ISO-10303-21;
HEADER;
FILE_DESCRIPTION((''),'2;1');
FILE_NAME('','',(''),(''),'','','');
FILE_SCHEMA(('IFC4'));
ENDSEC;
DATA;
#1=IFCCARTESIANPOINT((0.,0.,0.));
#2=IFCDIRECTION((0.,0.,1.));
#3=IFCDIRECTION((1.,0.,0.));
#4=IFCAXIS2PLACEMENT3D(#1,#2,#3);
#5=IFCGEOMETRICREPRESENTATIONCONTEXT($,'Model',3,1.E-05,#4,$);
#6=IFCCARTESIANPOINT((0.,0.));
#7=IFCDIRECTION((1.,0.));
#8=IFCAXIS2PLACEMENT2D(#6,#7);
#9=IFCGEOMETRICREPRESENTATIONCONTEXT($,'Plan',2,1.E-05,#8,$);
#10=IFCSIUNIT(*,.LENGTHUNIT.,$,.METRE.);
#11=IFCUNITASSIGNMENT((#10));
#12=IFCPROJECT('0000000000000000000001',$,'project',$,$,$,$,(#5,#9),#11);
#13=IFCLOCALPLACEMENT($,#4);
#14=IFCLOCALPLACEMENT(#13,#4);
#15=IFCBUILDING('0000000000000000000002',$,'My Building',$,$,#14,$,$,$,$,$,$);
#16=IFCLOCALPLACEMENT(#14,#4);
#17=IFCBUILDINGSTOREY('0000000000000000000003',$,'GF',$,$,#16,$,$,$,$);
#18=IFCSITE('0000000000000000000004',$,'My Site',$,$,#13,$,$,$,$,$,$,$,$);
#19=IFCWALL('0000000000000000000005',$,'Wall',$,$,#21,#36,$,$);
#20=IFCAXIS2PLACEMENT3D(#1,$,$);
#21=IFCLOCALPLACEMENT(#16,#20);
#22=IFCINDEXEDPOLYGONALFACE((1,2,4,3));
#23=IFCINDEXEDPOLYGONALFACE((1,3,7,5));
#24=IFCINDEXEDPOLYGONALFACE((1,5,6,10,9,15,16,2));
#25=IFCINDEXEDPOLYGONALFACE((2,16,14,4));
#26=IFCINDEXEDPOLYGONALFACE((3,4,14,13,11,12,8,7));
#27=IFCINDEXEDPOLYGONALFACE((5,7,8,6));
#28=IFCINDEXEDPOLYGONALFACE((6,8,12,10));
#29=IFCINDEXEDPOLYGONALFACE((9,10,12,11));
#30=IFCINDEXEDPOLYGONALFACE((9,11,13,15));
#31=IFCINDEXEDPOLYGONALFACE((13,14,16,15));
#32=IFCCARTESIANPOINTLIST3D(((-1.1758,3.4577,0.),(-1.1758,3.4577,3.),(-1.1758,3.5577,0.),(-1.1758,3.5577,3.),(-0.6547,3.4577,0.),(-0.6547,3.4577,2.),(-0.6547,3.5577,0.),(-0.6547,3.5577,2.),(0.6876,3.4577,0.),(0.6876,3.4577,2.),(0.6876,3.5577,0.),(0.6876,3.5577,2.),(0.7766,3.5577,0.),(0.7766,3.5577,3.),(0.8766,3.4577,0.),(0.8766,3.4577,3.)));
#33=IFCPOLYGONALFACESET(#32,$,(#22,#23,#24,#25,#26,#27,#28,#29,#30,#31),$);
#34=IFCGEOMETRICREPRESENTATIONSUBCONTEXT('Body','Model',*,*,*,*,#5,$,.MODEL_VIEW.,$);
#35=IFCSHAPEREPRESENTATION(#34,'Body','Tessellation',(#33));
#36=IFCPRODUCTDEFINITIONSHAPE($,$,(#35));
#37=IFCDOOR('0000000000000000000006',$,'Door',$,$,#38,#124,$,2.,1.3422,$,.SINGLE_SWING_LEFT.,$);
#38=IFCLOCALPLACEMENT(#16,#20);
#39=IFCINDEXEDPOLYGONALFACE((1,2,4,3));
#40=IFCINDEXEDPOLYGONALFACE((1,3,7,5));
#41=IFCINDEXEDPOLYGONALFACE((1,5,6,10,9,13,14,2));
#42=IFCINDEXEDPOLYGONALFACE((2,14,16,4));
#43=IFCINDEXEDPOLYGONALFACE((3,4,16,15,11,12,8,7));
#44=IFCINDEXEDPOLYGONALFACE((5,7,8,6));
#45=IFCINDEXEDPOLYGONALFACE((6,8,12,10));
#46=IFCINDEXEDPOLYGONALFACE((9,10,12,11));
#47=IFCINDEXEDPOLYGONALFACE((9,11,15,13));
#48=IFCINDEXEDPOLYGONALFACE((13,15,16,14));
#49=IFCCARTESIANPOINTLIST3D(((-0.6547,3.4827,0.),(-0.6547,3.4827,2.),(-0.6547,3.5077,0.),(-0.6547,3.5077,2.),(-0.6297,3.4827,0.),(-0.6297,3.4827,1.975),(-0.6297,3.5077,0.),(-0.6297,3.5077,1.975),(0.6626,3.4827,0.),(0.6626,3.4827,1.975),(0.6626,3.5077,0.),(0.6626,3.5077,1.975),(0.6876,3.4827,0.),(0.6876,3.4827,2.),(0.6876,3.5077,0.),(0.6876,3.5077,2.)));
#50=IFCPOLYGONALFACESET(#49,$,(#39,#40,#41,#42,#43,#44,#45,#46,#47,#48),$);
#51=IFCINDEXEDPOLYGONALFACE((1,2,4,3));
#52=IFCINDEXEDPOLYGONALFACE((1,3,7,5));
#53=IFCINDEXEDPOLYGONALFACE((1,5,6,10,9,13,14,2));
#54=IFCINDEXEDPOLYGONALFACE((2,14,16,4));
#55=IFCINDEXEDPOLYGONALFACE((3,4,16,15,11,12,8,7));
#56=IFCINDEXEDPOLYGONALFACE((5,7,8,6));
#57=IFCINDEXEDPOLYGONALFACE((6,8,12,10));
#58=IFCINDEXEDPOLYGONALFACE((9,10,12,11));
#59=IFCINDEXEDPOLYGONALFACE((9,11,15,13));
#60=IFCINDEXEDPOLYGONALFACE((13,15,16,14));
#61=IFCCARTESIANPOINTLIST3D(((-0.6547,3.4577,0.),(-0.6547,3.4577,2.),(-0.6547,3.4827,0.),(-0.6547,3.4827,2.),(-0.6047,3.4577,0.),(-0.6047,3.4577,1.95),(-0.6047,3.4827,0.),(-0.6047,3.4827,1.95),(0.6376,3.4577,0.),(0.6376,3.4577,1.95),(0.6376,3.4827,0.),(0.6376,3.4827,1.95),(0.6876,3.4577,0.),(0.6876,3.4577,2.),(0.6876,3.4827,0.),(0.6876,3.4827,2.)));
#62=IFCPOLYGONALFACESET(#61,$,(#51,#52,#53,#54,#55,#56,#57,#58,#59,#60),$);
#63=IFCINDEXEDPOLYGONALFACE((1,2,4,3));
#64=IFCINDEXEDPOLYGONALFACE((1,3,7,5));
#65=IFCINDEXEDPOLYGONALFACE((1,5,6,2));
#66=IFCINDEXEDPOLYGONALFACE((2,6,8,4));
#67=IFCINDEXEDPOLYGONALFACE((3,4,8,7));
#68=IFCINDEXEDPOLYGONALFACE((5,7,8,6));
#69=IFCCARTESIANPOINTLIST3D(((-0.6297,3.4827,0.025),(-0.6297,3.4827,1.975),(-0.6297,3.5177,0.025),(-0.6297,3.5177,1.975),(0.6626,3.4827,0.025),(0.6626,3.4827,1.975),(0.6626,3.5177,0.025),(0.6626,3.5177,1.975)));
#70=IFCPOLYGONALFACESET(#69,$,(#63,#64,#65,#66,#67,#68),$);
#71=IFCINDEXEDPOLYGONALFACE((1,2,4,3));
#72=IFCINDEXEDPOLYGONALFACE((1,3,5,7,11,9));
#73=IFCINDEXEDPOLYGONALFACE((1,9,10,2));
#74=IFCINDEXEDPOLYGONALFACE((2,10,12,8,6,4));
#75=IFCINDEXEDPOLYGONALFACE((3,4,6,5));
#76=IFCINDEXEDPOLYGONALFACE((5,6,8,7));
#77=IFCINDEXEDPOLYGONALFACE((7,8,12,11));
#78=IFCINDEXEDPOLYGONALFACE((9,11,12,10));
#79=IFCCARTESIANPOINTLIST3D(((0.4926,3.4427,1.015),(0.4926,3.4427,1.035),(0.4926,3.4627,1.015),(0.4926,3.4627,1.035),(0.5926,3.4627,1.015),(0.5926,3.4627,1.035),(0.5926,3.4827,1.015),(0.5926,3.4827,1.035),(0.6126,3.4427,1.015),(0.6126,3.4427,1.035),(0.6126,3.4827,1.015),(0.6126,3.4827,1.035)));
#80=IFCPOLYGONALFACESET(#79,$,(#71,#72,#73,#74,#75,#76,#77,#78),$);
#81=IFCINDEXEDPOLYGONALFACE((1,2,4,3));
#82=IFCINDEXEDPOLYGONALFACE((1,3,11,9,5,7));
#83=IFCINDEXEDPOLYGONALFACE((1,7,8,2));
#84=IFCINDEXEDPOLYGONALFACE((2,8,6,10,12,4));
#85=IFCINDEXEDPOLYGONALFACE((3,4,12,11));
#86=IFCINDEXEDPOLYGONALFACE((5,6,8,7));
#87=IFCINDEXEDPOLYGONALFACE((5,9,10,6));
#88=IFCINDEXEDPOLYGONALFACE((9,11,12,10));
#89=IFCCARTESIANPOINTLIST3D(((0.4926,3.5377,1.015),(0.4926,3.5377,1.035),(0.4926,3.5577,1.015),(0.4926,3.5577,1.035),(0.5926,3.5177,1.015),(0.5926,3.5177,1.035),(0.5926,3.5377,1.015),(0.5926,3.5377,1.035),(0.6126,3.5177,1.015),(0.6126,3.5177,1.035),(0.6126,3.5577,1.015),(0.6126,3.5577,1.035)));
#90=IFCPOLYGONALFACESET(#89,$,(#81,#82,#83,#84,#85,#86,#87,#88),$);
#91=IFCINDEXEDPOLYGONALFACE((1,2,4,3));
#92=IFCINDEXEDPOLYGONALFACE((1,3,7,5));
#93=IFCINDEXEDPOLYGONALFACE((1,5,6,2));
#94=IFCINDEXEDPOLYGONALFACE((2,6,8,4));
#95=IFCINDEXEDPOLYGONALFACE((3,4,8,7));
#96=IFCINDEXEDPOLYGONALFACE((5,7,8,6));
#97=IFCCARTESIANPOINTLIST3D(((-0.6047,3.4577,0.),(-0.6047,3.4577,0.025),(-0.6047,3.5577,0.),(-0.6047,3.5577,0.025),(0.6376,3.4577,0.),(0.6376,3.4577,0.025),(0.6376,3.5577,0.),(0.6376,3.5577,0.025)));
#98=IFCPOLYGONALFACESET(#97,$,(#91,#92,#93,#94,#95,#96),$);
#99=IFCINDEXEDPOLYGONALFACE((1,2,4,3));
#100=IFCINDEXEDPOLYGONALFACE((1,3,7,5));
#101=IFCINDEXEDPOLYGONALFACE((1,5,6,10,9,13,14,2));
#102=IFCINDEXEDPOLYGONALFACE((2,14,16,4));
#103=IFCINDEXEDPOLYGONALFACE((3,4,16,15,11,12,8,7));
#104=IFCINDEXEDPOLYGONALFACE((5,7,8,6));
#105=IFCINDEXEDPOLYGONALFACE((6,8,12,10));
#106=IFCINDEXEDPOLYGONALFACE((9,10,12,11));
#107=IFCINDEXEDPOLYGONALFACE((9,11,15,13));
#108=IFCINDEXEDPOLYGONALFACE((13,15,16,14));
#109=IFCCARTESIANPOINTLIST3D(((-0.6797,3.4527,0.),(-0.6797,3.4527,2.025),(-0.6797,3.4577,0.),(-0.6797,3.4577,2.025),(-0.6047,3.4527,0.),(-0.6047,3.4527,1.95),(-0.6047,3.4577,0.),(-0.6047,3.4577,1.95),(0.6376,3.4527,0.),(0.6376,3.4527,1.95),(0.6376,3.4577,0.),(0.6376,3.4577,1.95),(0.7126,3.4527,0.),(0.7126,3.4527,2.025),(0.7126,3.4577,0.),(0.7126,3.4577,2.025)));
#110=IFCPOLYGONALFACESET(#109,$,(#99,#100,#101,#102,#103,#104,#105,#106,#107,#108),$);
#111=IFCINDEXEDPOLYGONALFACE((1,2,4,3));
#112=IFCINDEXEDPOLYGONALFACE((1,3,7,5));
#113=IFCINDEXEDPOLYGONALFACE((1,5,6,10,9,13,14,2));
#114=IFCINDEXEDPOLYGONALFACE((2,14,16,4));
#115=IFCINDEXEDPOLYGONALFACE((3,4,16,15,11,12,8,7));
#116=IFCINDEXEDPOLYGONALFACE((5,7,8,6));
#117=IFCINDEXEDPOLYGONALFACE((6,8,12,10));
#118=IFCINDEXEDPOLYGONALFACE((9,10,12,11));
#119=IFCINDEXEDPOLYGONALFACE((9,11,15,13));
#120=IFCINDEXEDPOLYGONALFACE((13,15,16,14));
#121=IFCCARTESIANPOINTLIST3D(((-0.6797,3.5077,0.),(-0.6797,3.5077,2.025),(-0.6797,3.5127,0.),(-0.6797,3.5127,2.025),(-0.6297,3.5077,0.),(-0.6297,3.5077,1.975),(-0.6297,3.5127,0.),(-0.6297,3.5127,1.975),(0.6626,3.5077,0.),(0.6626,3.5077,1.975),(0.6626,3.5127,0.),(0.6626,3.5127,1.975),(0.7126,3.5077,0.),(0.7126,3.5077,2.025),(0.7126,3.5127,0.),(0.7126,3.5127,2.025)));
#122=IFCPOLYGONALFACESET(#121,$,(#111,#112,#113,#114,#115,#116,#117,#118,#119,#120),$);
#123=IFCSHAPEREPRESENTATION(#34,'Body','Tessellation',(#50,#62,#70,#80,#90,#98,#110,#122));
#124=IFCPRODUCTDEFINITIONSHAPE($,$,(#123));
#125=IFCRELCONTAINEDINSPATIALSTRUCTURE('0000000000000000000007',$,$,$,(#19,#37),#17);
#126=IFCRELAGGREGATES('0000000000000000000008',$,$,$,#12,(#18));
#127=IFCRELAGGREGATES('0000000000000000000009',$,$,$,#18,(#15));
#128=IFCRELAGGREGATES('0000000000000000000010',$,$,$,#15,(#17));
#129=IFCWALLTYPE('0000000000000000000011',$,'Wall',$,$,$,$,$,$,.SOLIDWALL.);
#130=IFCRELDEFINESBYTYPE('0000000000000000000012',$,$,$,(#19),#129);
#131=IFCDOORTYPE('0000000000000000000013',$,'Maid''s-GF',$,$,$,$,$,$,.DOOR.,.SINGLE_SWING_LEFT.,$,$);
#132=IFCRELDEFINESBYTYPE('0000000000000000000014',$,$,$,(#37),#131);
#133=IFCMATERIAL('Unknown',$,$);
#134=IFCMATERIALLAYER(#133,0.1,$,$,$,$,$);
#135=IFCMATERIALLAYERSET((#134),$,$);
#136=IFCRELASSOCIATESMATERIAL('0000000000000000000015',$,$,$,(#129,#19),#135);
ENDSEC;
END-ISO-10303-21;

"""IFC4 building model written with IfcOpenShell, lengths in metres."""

from ifc_helpers import new_model, entity, si_unit, frame, origin_with_axes, origin_2d_with_axis, place, context, subcontext, project, spatial, line, indexed_curve, outline, extrude, shape, source, transform, mapped, material, layer, layer_set, layer_usage, type_object, type_shapes, element, fill, save


model = new_model("IFC4")

# Units and contexts
model_context = context("Model", 3, precision=1e-05, world=origin_with_axes())
plan_context = context("Plan", 2, precision=1e-05, world=origin_2d_with_axis())
body_context_1 = subcontext(model_context, "Body", "Model", "MODEL_VIEW")
body_context_2 = subcontext(plan_context, "Body", "Plan", "PLAN_VIEW")
ifc_project = project(units=[si_unit("LENGTHUNIT", "METRE")], contexts=[model_context, plan_context])

# Site, building, storey
site_placement = place(None, origin_with_axes())
site = spatial("IfcSite", under=ifc_project, at=site_placement, Name="My Site")
building_placement = place(site_placement, origin_with_axes())
building = spatial("IfcBuilding", under=site, at=building_placement, Name="My Building")
storey_placement = place(building_placement, origin_with_axes())
storey = spatial("IfcBuildingStorey", under=building, at=storey_placement, Name="GF")

# Shared definitions
ifc_material_1 = material(Name="Unknown")

# Shared definitions
ifc_layer_1 = layer(ifc_material_1, 0.1)
ifc_layer_set_1 = layer_set([ifc_layer_1])
wall_type = type_object("IfcWallType", Name="Wall", PredefinedType="SOLIDWALL", material=ifc_layer_set_1)

# Wall, opening, door
ifc_layer_usage_1 = layer_usage(ifc_layer_set_1, "AXIS2", "POSITIVE", 0.0)
wall_1_placement = place(storey_placement, frame((0.7766, 3.5577, 0.0), z_axis=(0.0, 0.0, 1.0), x_axis=(-1.0, 0.0, 0.0)))
wall_1 = element("IfcWall", 1, at=wall_1_placement, inside=storey, type_object=wall_type, material=ifc_layer_usage_1, Name="Wall", context=body_context_1, shape_type="SweptSolid", body=[
    extrude(outline(indexed_curve([(0.0, 0.0), (-0.1, 0.1), (1.9525, 0.1), (1.9525, 0.0)], segments=[line(1, 2, 3, 4, 1)])), origin_with_axes(), (0.0, 0.0, 1.0), 3.0),
])
shared_shape_1 = source(origin_with_axes(), body_context_1, "Body", "SweptSolid", [
    extrude(outline(indexed_curve([(0.0, 0.0), (1.3422, 0.0), (1.3422, 2.0), (0.0, 2.0)], segments=[line(1, 2, 3, 4, 1)])), frame((0.0, -0.6, 0.0), z_axis=(0.0, -1.0, 0.0), x_axis=(1.0, 0.0, 0.0)), (0.0, 0.0, -1.0), 1.2),
])
opening_1_placement = place(wall_1_placement, frame((1.4313, 0.1, 0.0), z_axis=(0.0, 0.0, 1.0), x_axis=(-1.0, 0.000001, 0.0)))
opening_1 = element("IfcOpeningElement", 2, at=opening_1_placement, cuts=wall_1, PredefinedType="OPENING", context=body_context_1, shape_type="MappedRepresentation", body=[
    mapped(shared_shape_1, transform((0.0, 0.0, 0.0), x_axis=(1.0, 0.0, 0.0), y_axis=(0.0, 1.0, 0.0), z_axis=(0.0, 0.0, 1.0), scale=1.0)),
])
door_type_1 = type_object("IfcDoorType", Name="Maid's-GF", OperationType="SINGLE_SWING_LEFT", PredefinedType="DOOR")
shared_shape_2 = source(origin_with_axes(), body_context_1, "Body", "SweptSolid", [
    extrude(outline(indexed_curve([(0.0, 0.0), (0.0, 2.0), (1.3422, 2.0), (1.3422, 0.0), (1.3172, 0.0), (1.3172, 1.975), (0.025, 1.975), (0.025, 0.0)], segments=[line(1, 2, 3, 4, 5, 6, 7, 8, 1)])), frame((0.0, 0.025, 0.0), z_axis=(0.0, -1.0, 0.0), x_axis=(1.0, 0.0, 0.0)), (0.0, 0.0, -1.0), 0.025),
    extrude(outline(indexed_curve([(0.0, 0.0), (0.0, 2.0), (1.3422, 2.0), (1.3422, 0.0), (1.2922, 0.0), (1.2922, 1.95), (0.05, 1.95), (0.05, 0.0)], segments=[line(1, 2, 3, 4, 5, 6, 7, 8, 1)])), frame((0.0, 0.0, 0.0), z_axis=(0.0, -1.0, 0.0), x_axis=(1.0, 0.0, 0.0)), (0.0, 0.0, -1.0), 0.025),
    extrude(outline(indexed_curve([(0.0, 0.0), (1.2922, 0.0), (1.2922, 0.035), (0.0, 0.035)], segments=[line(1, 2, 3, 4, 1)])), frame((0.025, 0.025, 0.025), z_axis=(0.0, 0.0, 1.0), x_axis=(1.0, 0.0, 0.0)), (0.0, 0.0, 1.0), 1.95),
    extrude(outline(indexed_curve([(0.0, 0.0), (0.0, -0.04), (-0.12, -0.04), (-0.12, -0.02), (-0.02, -0.02), (-0.02, 0.0)], segments=[line(1, 2, 3, 4, 5, 6, 1)])), frame((1.2672, 0.025, 1.015), z_axis=(0.0, 0.0, 1.0), x_axis=(1.0, 0.0, 0.0)), (0.0, 0.0, 1.0), 0.02),
    extrude(outline(indexed_curve([(0.0, 0.0), (0.0, 0.04), (-0.12, 0.04), (-0.12, 0.02), (-0.02, 0.02), (-0.02, 0.0)], segments=[line(1, 2, 3, 4, 5, 6, 1)])), frame((1.2672, 0.06, 1.015), z_axis=(0.0, 0.0, 1.0), x_axis=(1.0, 0.0, 0.0)), (0.0, 0.0, 1.0), 0.02),
    extrude(outline(indexed_curve([(0.0, 0.0), (1.2422, 0.0), (1.2422, 0.1), (0.0, 0.1)], segments=[line(1, 2, 3, 4, 1)])), frame((0.05, 0.0, 0.0), z_axis=(0.0, 0.0, 1.0), x_axis=(1.0, 0.0, 0.0)), (0.0, 0.0, 1.0), 0.025),
    extrude(outline(indexed_curve([(0.0, 0.0), (0.0, 2.025), (1.3922, 2.025), (1.3922, 0.0), (1.3172, 0.0), (1.3172, 1.95), (0.075, 1.95), (0.075, 0.0)], segments=[line(1, 2, 3, 4, 5, 6, 7, 8, 1)])), frame((-0.025, -0.005, 0.0), z_axis=(0.0, -1.0, 0.0), x_axis=(1.0, 0.0, 0.0)), (0.0, 0.0, -1.0), 0.005),
    extrude(outline(indexed_curve([(0.0, 0.0), (0.0, 2.025), (1.3922, 2.025), (1.3922, 0.0), (1.3422, 0.0), (1.3422, 1.975), (0.05, 1.975), (0.05, 0.0)], segments=[line(1, 2, 3, 4, 5, 6, 7, 8, 1)])), frame((-0.025, 0.05, 0.0), z_axis=(0.0, -1.0, 0.0), x_axis=(1.0, 0.0, 0.0)), (0.0, 0.0, -1.0), 0.005),
])
shared_shape_3 = source(origin_with_axes(), body_context_2, "Body", "Curve2D", [
    entity("IfcIndexedPolyCurve", entity("IfcCartesianPointList2D", [[0.0, 0.0], [0.0, 0.05], [0.025, 0.05], [0.025, 0.025], [0.05, 0.025], [0.05, 0.0]]), [entity("IfcLineIndex", [1, 2, 3, 4, 5, 6, 1])]),
    entity("IfcIndexedPolyCurve", entity("IfcCartesianPointList2D", [[1.3422, 0.0], [1.3422, 0.05], [1.3172, 0.05], [1.3172, 0.025], [1.2922, 0.025], [1.2922, 0.0]]), [entity("IfcLineIndex", [1, 2, 3, 4, 5, 6, 1])]),
    entity("IfcTrimmedCurve", entity("IfcEllipse", entity("IfcAxis2Placement2D", entity("IfcCartesianPoint", [0.06, 0.05]), entity("IfcDirection", [1.0, 0.0])), 1.2572, 1.2922), [entity("IfcCartesianPoint", [1.3172, 0.05])], [entity("IfcCartesianPoint", [0.06, 1.3422])], True, "CARTESIAN"),
    entity("IfcIndexedPolyCurve", entity("IfcCartesianPointList2D", [[0.025, 0.05], [0.06, 0.05], [0.06, 1.3422], [0.025, 1.3422]]), [entity("IfcLineIndex", [1, 2, 3, 4, 1])]),
])
type_shapes(door_type_1, [shared_shape_2, shared_shape_3])
door_1_placement = place(opening_1_placement, frame((0.0, 0.0, 0.0), z_axis=(0.0, 0.0, 1.0), x_axis=(1.0, 0.0, 0.0)))
door_1 = element("IfcDoor", 3, at=door_1_placement, inside=storey, type_object=door_type_1, Name="Door", OperationType="SINGLE_SWING_LEFT", OverallHeight=2.0, OverallWidth=1.3422, shapes=[
    shape(body_context_1, "Body", "MappedRepresentation", [mapped(shared_shape_2, transform((0.0, 0.0, 0.0), x_axis=(1.0, 0.0, 0.0), y_axis=(0.0, 1.0, 0.0), z_axis=(0.0, 0.0, 1.0), scale=1.0))]),
    shape(body_context_2, "Body", "MappedRepresentation", [mapped(shared_shape_3, transform((0.0, 0.0, 0.0), x_axis=(1.0, 0.0, 0.0), y_axis=(0.0, 1.0, 0.0), z_axis=(0.0, 0.0, 1.0), scale=1.0))]),
])
fill(opening_1, door_1)

save(model, "model.ifc")
